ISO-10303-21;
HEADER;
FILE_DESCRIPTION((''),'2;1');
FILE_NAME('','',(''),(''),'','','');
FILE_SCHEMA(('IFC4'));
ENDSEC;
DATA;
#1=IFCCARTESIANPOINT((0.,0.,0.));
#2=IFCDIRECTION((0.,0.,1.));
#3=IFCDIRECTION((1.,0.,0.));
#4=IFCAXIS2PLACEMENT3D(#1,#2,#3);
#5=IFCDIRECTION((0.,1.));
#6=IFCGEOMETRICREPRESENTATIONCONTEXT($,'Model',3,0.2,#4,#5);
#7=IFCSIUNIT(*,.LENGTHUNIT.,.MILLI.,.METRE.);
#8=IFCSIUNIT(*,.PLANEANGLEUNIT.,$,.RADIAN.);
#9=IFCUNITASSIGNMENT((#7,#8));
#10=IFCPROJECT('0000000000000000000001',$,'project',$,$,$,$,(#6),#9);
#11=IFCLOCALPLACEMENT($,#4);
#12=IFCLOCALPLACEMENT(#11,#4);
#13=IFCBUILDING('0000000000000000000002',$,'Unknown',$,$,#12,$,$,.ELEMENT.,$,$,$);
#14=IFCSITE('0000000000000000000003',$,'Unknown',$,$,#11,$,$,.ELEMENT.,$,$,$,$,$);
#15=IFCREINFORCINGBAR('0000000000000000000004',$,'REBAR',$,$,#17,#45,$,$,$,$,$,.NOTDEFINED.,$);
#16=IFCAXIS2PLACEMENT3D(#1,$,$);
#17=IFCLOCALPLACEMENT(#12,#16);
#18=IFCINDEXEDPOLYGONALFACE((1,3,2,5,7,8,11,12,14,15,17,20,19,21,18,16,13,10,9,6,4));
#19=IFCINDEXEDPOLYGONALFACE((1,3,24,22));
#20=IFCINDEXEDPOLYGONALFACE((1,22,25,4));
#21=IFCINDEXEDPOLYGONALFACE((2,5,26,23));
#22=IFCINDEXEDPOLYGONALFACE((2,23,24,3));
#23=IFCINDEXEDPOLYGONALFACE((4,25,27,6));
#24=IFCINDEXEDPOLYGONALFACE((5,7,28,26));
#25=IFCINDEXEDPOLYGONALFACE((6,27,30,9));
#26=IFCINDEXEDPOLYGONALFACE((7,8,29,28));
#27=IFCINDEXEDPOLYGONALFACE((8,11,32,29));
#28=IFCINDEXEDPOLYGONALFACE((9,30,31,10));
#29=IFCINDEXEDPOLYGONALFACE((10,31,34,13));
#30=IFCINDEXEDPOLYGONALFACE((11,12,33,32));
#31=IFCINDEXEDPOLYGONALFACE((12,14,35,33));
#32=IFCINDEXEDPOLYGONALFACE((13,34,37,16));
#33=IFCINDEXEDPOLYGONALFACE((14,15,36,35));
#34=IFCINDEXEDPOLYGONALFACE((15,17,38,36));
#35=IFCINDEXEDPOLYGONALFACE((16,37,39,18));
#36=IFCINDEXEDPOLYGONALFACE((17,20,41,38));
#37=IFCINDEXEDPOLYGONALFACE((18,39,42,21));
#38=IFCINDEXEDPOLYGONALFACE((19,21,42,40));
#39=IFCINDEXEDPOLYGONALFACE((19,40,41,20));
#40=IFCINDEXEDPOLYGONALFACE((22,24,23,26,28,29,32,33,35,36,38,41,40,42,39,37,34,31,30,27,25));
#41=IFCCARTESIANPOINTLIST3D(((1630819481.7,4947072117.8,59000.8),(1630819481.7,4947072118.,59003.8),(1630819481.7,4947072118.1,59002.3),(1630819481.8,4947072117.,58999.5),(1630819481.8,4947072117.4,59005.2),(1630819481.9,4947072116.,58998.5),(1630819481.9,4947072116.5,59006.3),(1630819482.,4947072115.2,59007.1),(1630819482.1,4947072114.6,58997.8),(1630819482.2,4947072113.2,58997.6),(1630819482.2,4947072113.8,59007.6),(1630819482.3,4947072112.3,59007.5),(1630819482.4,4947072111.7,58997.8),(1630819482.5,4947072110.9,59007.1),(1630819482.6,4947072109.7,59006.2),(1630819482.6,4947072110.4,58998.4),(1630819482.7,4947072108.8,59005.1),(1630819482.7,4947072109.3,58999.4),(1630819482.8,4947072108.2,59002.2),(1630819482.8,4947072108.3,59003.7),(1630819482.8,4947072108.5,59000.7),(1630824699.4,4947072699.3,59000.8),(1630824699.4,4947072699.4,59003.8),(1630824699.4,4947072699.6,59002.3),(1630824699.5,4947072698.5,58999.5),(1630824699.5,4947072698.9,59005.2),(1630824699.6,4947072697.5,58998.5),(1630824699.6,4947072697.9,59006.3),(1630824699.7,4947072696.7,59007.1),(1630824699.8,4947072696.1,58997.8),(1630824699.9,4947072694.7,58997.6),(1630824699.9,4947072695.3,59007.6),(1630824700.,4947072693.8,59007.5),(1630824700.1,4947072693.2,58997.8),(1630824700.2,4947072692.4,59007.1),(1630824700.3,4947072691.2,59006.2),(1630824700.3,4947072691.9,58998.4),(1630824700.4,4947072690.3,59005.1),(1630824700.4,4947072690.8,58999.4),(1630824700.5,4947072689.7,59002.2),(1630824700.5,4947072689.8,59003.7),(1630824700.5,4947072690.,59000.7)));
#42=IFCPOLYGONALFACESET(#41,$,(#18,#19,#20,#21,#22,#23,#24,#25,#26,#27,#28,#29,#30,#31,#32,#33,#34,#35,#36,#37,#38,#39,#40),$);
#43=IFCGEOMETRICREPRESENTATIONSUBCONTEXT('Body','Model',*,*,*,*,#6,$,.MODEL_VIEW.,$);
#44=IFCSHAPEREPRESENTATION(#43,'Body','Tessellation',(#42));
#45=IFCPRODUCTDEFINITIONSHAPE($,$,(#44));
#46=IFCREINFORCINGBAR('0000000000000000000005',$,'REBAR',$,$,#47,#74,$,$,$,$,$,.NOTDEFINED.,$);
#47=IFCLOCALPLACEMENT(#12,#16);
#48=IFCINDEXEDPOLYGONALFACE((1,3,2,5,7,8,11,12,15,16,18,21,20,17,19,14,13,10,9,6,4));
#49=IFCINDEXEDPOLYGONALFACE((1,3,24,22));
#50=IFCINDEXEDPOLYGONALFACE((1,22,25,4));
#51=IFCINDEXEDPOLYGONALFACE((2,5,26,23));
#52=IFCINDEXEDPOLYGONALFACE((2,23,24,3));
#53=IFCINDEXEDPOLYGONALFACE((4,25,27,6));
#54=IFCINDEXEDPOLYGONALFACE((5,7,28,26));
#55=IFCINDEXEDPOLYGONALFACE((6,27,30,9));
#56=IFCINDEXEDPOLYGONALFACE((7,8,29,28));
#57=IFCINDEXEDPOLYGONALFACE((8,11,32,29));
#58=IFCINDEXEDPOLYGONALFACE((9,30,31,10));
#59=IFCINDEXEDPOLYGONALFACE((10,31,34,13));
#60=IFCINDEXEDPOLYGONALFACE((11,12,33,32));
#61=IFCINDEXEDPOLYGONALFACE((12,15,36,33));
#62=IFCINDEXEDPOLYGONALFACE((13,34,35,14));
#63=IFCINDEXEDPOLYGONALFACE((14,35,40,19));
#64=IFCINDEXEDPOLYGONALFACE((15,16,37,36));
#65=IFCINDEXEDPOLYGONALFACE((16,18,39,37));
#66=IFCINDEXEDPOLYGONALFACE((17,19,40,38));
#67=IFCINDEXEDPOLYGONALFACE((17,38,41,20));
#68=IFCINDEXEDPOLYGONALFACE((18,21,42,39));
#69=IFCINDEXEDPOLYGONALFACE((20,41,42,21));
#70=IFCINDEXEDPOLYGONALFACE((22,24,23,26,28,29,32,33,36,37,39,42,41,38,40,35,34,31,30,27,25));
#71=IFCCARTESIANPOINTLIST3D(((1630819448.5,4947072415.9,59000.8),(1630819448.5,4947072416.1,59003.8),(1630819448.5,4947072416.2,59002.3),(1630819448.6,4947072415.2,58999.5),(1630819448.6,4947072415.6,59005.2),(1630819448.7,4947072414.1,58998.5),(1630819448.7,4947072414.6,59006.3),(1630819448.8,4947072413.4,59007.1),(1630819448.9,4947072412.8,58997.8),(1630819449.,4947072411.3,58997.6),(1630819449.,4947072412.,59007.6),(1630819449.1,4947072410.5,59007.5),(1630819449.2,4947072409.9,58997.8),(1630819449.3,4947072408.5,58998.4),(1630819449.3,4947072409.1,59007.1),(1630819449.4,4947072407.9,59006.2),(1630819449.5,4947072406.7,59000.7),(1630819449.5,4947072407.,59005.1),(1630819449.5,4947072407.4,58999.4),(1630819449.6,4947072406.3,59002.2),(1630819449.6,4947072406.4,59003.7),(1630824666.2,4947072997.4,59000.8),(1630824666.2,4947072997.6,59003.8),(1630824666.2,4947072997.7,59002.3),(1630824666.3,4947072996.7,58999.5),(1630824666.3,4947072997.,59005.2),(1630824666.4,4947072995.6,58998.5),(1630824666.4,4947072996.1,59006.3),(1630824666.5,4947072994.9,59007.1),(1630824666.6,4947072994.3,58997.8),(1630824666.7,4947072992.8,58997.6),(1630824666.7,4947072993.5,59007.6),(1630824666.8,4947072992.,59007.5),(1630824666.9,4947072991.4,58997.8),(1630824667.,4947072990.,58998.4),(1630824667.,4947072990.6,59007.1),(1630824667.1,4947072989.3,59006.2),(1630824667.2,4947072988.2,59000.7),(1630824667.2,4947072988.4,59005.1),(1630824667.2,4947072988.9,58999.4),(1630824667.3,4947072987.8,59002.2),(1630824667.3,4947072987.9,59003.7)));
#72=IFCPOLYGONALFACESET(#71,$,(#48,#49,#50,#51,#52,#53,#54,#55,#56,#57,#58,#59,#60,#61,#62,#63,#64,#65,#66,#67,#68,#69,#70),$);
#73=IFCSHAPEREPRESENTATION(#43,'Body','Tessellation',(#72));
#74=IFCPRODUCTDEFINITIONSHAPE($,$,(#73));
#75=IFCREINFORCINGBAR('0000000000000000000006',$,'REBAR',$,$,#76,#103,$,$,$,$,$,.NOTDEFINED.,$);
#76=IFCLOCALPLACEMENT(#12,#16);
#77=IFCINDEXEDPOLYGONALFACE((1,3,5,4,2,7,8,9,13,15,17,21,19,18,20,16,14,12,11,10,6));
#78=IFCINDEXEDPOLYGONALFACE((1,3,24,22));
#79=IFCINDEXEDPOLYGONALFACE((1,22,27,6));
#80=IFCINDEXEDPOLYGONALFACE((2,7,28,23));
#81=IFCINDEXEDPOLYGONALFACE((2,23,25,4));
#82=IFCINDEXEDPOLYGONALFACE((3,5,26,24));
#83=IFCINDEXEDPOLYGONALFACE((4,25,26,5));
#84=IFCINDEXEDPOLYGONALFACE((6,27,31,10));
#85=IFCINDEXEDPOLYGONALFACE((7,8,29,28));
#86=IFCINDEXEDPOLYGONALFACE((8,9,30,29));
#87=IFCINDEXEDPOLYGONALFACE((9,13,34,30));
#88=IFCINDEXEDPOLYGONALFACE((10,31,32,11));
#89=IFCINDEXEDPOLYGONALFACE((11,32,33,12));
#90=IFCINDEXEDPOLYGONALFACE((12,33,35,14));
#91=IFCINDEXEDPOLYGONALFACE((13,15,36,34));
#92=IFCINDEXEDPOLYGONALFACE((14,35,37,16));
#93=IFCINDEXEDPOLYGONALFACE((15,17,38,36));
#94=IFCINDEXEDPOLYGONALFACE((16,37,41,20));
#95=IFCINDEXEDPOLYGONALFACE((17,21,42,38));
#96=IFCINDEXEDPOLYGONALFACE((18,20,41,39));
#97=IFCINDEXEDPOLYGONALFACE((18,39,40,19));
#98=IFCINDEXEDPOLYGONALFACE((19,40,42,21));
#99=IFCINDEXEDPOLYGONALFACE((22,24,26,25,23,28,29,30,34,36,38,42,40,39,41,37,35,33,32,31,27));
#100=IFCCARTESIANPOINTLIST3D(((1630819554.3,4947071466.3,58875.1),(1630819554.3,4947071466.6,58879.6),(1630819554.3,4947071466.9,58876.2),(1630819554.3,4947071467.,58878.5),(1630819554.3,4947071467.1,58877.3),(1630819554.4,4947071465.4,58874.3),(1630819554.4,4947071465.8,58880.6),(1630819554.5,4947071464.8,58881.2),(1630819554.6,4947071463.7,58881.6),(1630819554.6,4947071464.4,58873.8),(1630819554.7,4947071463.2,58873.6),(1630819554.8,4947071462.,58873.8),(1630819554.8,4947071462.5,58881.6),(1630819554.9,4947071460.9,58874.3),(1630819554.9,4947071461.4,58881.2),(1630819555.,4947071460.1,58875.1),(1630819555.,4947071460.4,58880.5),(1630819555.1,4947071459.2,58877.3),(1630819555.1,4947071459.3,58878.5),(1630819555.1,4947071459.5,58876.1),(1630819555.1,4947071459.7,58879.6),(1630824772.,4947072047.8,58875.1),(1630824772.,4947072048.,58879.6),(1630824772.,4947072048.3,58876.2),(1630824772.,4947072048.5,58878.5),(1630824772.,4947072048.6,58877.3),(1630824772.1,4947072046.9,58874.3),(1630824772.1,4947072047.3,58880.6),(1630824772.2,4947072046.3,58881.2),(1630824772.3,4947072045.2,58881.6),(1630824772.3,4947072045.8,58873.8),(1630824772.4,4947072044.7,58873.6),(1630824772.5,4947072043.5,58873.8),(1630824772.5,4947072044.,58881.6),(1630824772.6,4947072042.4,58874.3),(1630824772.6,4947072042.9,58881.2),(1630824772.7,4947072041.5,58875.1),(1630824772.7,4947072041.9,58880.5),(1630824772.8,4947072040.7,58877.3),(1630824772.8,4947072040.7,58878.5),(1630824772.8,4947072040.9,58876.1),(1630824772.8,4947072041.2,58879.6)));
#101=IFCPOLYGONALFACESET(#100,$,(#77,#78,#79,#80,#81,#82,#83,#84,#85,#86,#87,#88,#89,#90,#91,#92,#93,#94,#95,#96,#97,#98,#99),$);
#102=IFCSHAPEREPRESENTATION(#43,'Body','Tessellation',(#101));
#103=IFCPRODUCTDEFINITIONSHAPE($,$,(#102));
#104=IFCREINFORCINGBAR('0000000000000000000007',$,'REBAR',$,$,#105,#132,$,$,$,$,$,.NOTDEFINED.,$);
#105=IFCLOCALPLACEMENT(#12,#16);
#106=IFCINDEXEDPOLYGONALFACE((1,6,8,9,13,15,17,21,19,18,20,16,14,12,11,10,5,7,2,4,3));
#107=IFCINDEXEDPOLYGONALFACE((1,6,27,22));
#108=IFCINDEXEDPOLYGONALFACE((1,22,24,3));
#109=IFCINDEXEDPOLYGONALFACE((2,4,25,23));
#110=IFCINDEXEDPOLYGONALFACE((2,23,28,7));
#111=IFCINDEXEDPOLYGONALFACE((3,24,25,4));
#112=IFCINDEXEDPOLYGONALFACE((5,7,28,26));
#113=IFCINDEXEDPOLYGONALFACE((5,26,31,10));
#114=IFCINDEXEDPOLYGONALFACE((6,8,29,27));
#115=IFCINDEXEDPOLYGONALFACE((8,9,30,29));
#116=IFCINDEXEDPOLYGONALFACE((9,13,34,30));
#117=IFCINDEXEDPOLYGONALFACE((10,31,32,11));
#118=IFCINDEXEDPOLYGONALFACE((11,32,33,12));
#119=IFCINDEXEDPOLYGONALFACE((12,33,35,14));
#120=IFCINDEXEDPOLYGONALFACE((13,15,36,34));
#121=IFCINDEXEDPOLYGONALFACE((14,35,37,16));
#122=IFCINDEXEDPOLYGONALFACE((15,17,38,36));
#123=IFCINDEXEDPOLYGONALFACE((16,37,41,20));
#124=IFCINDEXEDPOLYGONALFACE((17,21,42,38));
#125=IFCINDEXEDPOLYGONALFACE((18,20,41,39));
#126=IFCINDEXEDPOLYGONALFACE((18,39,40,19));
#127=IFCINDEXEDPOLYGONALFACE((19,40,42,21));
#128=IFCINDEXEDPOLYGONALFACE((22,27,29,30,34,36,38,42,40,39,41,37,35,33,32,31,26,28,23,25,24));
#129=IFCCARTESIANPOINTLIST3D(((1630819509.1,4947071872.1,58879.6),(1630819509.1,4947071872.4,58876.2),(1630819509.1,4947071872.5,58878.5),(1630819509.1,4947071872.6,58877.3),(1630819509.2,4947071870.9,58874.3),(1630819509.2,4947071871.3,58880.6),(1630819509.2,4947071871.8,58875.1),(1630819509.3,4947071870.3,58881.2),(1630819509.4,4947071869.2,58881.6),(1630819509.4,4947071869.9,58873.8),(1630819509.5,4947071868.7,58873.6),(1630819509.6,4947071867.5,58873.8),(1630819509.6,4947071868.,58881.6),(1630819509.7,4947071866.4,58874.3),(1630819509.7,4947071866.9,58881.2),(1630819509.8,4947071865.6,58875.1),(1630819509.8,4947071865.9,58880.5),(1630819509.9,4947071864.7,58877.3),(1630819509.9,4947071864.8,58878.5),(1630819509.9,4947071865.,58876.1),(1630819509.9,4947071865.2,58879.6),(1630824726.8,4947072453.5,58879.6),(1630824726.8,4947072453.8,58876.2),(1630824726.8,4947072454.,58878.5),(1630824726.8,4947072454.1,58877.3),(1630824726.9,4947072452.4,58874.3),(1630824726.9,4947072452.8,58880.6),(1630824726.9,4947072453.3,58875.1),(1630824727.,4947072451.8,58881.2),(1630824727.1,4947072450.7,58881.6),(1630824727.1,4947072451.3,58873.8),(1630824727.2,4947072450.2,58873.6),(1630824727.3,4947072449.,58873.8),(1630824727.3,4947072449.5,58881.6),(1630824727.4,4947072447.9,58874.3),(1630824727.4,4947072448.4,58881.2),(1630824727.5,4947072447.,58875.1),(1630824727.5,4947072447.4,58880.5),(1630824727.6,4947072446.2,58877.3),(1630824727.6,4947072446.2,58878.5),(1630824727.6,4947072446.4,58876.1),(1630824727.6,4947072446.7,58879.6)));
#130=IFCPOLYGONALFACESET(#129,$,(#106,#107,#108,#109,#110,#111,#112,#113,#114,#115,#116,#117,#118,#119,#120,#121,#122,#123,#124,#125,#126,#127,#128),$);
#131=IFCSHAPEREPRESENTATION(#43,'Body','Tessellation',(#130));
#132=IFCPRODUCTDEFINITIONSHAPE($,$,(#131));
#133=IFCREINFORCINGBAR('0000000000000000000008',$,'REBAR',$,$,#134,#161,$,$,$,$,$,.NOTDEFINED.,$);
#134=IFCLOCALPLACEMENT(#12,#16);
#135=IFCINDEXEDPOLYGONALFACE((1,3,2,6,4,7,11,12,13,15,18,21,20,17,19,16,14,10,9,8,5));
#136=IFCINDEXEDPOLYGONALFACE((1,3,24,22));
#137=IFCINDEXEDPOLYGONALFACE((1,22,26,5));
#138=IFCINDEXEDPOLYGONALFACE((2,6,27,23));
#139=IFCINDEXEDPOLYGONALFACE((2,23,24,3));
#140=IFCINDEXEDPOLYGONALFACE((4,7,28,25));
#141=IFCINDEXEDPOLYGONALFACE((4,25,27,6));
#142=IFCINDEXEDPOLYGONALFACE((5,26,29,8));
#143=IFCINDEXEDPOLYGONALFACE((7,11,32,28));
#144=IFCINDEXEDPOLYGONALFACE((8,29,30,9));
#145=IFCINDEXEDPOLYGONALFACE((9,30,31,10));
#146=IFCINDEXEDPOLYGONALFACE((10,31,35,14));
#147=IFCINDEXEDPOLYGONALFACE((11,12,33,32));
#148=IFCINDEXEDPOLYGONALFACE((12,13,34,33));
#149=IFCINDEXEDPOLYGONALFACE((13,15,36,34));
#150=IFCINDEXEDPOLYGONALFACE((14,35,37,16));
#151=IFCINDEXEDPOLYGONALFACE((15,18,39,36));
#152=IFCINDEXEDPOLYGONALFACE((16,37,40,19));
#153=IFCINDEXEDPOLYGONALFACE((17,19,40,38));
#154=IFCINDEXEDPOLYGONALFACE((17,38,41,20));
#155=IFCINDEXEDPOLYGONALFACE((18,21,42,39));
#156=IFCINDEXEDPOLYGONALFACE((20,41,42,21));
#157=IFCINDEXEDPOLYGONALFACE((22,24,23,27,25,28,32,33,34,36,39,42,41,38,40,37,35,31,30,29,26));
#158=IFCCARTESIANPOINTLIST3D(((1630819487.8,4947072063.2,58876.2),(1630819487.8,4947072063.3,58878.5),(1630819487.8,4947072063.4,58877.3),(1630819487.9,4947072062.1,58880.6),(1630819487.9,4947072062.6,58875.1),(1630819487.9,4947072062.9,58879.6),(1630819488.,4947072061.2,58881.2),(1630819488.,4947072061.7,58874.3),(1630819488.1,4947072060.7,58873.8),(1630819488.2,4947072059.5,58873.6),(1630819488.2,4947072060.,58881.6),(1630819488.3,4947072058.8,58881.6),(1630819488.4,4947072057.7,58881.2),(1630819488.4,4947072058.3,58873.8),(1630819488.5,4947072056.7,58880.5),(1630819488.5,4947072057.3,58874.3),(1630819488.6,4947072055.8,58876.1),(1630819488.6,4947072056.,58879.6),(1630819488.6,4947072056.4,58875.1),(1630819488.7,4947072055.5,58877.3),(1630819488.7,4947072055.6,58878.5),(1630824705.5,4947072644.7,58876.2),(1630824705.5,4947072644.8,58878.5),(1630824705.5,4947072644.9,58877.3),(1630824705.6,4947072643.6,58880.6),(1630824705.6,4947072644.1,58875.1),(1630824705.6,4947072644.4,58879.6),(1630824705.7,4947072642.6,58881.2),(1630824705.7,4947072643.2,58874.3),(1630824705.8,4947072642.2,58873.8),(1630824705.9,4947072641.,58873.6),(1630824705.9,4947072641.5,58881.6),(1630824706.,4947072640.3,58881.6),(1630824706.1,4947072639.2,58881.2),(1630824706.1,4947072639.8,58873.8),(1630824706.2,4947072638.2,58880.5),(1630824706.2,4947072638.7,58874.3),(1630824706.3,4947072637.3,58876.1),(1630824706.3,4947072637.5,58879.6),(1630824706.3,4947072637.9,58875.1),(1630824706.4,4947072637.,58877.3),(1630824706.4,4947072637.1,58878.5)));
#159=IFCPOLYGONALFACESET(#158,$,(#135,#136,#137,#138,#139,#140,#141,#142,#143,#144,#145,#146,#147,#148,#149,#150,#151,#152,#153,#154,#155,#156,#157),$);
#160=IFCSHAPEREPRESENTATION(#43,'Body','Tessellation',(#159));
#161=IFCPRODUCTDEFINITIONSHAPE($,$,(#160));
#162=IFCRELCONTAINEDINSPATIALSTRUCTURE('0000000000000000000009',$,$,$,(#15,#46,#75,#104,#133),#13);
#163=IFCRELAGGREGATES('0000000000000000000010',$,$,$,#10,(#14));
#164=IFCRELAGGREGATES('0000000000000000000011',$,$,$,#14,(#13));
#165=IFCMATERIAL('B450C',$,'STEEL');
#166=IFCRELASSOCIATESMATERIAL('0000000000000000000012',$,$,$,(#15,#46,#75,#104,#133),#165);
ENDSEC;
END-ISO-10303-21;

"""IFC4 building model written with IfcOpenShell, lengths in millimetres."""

from ifc_helpers import new_model, entity, si_unit, direction, frame, origin_with_axes, place, context, subcontext, project, spatial, material, element, save


model = new_model("IFC4")

# Units and contexts
model_context = context("Model", 3, precision=0.2, world=origin_with_axes(), true_north=direction((0.0, 1.0)))
body_context = subcontext(model_context, "Body", "Model", "MODEL_VIEW")
ifc_project = project(units=[si_unit("LENGTHUNIT", "METRE", prefix="MILLI"), si_unit("PLANEANGLEUNIT", "RADIAN")], contexts=[model_context])

# Site, building
site_placement = place(None, origin_with_axes())
site = spatial("IfcSite", under=ifc_project, at=site_placement, Name="Unknown", CompositionType="ELEMENT")
building_placement = place(site_placement, origin_with_axes())
building = spatial("IfcBuilding", under=site, at=building_placement, Name="Unknown", CompositionType="ELEMENT")

# Reinforcing bars
ifc_material = material(Name="B450C", Category="STEEL")
for number, where, z_axis, x_axis, name in (
    (1, (1630819482.3, 4947072113.1, 59002.6), (-0.007106, 0.063762, 0.99794), (0.993847, 0.110757, 0.0), "REBAR"),
    (2, (1630819449.0, 4947072411.3, 59002.6), (-0.007106, 0.063762, 0.99794), (0.993847, 0.110757, 0.0), "REBAR"),
):
    element("IfcReinforcingBar", number, at=place(building_placement, frame(where, z_axis=z_axis, x_axis=x_axis)), inside=building, material=ifc_material, Name=name, PredefinedType="NOTDEFINED", context=body_context, shape_type="AdvancedSweptSolid", body=[
        entity("IfcSweptDiskSolid", entity("IfcIndexedPolyCurve", entity("IfcCartesianPointList3D", [[0.0, 0.0, 0.0], [5250.0, 0.0, 0.0]]), [entity("IfcLineIndex", [1, 2])]), 5.0),
    ])
for number, where, z_axis, x_axis, name in (
    (3, (1630819554.7, 4947071463.1, 58877.6), (-0.007106, 0.063762, 0.99794), (0.993847, 0.110757, 0.0), "REBAR"),
    (4, (1630819509.5, 4947071868.6, 58877.6), (-0.007106, 0.063762, 0.99794), (0.993847, 0.110757, 0.0), "REBAR"),
    (5, (1630819488.2, 4947072059.5, 58877.6), (-0.007106, 0.063762, 0.99794), (0.993847, 0.110757, 0.0), "REBAR"),
):
    element("IfcReinforcingBar", number, at=place(building_placement, frame(where, z_axis=z_axis, x_axis=x_axis)), inside=building, material=ifc_material, Name=name, PredefinedType="NOTDEFINED", context=body_context, shape_type="AdvancedSweptSolid", body=[
        entity("IfcSweptDiskSolid", entity("IfcIndexedPolyCurve", entity("IfcCartesianPointList3D", [[0.0, 0.0, 0.0], [5250.0, 0.0, 0.0]]), [entity("IfcLineIndex", [1, 2])]), 4.0),
    ])

save(model, "model.ifc")
